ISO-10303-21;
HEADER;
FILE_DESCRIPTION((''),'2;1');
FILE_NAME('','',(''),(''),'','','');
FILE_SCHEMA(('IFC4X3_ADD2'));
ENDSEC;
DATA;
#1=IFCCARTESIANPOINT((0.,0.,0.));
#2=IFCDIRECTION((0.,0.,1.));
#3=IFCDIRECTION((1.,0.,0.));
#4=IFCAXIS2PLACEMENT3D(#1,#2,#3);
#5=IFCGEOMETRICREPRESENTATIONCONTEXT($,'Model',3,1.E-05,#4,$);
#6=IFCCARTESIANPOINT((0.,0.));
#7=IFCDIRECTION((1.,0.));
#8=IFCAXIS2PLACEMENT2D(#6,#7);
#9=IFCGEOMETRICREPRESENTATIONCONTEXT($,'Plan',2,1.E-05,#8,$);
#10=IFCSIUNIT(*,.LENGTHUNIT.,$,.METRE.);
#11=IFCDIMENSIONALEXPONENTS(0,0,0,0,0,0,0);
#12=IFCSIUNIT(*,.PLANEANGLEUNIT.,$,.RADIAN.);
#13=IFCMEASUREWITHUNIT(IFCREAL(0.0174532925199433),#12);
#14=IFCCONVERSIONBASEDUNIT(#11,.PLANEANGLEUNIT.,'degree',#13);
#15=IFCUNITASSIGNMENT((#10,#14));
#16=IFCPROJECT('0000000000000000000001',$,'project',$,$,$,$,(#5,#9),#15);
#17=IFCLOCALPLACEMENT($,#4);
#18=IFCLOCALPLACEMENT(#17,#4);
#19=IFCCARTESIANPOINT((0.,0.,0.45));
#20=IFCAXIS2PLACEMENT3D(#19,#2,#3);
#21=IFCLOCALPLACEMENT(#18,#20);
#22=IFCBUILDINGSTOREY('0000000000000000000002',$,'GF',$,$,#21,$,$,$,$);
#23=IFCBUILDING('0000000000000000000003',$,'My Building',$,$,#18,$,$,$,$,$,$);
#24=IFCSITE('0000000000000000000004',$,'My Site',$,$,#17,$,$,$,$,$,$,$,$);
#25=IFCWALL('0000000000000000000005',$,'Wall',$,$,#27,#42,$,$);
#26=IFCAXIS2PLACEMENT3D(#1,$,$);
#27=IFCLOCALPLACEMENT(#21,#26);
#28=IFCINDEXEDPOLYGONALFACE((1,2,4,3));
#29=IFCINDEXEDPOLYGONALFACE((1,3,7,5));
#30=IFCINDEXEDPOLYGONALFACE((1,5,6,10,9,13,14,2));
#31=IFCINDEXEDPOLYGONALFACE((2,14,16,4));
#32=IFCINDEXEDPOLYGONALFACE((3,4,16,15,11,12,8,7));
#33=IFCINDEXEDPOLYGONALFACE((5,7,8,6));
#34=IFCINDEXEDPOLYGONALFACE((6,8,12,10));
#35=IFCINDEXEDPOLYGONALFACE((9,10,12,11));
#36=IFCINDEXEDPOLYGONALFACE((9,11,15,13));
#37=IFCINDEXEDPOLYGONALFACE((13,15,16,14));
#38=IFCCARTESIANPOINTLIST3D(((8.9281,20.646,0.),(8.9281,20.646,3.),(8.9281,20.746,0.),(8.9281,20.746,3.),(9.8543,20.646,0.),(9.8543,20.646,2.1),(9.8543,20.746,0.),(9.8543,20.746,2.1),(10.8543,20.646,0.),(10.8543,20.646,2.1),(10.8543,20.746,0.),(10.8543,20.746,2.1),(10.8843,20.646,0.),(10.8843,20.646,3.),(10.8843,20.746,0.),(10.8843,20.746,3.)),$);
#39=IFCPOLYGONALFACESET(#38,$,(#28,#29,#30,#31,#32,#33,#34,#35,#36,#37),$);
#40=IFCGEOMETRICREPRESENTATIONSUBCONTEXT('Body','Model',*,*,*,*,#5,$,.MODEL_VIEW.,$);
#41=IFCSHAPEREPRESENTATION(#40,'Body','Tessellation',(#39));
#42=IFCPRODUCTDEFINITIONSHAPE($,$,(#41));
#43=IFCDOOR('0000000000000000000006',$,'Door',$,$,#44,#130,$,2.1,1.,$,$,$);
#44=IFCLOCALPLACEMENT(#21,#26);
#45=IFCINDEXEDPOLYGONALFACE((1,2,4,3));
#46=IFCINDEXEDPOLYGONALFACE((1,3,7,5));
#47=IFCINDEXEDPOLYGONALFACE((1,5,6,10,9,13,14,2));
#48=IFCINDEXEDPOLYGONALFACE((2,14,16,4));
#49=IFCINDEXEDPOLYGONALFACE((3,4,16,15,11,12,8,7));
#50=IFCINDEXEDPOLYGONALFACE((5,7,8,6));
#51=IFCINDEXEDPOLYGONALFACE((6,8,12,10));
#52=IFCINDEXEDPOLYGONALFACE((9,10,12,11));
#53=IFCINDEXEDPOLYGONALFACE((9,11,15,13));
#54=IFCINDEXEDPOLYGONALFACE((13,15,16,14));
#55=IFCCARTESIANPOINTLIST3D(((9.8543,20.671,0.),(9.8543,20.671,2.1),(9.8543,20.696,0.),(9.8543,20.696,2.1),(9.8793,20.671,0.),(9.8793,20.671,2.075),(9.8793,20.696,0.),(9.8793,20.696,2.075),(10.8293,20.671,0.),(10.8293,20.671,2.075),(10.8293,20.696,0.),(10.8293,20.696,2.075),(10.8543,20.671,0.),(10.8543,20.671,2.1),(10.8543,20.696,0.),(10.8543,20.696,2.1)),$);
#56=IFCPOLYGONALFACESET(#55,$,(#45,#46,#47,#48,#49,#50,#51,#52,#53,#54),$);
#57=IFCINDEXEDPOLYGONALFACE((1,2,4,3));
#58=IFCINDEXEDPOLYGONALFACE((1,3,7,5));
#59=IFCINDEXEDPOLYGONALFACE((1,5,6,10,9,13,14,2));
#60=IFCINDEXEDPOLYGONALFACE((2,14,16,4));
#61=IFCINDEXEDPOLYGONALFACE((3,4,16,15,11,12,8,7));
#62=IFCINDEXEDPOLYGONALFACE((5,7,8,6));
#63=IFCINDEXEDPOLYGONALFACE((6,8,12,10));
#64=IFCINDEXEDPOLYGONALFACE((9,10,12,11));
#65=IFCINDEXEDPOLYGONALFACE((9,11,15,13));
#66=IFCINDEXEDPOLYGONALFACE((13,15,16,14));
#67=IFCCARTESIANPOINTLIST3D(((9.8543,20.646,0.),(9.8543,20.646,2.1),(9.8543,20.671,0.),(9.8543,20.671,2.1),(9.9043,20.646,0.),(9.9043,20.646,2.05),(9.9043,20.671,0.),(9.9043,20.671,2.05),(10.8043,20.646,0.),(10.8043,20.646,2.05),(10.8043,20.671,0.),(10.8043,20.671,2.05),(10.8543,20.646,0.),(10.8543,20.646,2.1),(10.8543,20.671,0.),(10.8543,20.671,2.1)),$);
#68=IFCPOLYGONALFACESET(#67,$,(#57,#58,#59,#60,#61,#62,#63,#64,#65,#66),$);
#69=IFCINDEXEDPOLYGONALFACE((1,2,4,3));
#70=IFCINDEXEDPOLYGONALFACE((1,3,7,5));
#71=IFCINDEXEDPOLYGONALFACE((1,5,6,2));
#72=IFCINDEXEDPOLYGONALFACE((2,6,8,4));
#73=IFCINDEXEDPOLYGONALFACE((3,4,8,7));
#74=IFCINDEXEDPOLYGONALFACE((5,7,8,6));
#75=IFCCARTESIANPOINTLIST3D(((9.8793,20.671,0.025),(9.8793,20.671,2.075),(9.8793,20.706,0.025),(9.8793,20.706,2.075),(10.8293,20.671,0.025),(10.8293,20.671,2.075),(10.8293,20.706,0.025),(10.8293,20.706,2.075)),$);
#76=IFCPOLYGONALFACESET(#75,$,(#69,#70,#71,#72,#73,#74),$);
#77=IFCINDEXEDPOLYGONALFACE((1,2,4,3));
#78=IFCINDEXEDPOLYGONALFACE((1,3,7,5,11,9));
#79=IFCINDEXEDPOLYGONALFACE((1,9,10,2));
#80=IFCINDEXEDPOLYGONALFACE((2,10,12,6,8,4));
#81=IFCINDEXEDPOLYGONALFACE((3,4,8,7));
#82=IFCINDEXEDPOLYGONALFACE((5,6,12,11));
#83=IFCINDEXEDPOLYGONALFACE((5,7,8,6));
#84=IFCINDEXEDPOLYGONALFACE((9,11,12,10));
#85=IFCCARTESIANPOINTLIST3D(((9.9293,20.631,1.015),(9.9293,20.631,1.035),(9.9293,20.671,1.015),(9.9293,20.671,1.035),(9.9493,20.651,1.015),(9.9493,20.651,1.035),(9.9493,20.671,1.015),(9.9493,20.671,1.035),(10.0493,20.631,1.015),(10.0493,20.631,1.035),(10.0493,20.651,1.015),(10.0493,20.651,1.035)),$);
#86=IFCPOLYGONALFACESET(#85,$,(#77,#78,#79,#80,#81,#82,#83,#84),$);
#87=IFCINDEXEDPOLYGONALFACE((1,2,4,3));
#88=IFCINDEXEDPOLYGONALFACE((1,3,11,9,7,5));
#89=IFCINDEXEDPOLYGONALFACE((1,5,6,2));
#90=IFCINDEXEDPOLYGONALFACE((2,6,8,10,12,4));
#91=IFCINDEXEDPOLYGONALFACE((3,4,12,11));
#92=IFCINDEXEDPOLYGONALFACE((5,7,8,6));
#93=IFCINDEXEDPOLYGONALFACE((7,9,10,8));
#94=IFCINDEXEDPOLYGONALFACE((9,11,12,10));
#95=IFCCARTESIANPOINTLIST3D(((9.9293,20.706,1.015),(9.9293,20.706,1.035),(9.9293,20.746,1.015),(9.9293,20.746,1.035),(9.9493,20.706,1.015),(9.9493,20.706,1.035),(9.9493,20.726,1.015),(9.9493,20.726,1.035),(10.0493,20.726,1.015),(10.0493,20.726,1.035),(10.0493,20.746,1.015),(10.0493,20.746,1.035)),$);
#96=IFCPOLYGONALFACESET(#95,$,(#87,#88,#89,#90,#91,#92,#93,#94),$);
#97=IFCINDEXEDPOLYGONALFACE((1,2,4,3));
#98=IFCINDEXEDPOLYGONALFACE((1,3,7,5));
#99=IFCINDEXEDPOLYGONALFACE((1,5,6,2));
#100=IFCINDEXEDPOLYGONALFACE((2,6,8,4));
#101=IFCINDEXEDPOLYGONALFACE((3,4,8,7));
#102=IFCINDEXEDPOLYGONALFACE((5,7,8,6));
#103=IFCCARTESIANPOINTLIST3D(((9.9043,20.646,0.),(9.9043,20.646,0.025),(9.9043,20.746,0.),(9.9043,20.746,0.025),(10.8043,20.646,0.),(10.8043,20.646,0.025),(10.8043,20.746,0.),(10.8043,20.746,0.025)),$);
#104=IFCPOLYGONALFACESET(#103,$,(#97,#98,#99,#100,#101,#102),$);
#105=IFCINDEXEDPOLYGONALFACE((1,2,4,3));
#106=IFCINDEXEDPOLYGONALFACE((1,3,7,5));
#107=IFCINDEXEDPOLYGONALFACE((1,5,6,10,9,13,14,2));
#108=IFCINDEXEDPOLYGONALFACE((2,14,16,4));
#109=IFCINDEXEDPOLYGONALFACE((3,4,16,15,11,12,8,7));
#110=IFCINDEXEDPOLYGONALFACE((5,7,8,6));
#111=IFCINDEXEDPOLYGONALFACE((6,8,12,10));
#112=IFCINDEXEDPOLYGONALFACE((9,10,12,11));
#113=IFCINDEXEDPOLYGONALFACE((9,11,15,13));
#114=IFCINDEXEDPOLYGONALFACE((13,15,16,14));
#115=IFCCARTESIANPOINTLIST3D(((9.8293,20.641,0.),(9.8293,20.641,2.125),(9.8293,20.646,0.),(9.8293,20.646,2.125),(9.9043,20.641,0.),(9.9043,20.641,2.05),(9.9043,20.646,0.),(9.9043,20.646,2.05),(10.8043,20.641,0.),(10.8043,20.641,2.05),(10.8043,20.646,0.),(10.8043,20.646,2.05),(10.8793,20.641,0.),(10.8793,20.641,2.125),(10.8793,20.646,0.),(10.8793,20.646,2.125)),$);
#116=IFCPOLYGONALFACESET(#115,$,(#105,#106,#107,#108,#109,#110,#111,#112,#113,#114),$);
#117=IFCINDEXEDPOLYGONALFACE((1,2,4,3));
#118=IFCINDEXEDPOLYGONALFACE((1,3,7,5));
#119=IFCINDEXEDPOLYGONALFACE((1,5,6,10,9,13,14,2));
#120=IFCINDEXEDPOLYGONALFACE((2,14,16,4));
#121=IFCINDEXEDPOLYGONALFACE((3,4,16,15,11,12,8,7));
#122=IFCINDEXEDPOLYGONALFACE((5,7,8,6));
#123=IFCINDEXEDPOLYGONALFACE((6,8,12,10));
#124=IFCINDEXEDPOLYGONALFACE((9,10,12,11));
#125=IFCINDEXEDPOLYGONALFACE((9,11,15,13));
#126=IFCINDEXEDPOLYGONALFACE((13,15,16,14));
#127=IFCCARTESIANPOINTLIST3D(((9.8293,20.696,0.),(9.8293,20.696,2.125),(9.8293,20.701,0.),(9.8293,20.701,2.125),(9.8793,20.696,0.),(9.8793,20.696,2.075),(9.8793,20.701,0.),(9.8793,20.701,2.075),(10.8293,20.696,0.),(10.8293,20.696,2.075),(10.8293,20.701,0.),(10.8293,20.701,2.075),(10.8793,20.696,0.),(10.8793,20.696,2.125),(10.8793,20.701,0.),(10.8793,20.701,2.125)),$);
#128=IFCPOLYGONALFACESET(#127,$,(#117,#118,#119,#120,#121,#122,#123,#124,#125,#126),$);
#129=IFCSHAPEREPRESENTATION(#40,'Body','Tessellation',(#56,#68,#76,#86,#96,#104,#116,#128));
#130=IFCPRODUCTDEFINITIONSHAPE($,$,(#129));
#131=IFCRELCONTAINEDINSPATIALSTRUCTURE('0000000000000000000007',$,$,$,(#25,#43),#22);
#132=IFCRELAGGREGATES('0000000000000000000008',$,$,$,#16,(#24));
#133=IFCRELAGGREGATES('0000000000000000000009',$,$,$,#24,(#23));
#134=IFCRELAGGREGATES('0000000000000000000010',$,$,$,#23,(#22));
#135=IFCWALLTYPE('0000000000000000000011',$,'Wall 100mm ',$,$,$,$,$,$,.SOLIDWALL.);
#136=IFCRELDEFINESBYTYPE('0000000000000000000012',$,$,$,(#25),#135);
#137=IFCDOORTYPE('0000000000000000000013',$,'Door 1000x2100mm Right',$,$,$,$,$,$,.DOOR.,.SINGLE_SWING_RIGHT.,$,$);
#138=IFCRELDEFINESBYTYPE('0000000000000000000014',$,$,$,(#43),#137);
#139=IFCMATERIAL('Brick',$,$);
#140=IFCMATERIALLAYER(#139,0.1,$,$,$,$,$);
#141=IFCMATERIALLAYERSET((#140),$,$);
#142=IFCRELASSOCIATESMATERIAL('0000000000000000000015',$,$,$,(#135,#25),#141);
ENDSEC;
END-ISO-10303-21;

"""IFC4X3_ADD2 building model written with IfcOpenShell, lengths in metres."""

from ifc_helpers import new_model, entity, si_unit, converted_unit, frame, origin_with_axes, origin_2d_with_axis, place, context, subcontext, project, spatial, line, indexed_curve, outline, extrude, shape, source, transform, mapped, material, layer, layer_set, layer_usage, type_object, type_shapes, element, fill, save


model = new_model("IFC4X3_ADD2")

# Units and contexts
model_context = context("Model", 3, precision=1e-05, world=origin_with_axes())
plan_context = context("Plan", 2, precision=1e-05, world=origin_2d_with_axis())
body_context_1 = subcontext(model_context, "Body", "Model", "MODEL_VIEW")
body_context_2 = subcontext(plan_context, "Body", "Plan", "PLAN_VIEW")
ifc_project = project(units=[si_unit("LENGTHUNIT", "METRE"), converted_unit("PLANEANGLEUNIT", "degree", entity("IfcReal", 0.0174532925199433), si_unit("PLANEANGLEUNIT", "RADIAN"), dimensions=[0, 0, 0, 0, 0, 0, 0])], contexts=[model_context, plan_context])

# Site, building, storey
site_placement = place(None, origin_with_axes())
site = spatial("IfcSite", under=ifc_project, at=site_placement, Name="My Site")
building_placement = place(site_placement, origin_with_axes())
building = spatial("IfcBuilding", under=site, at=building_placement, Name="My Building")
storey_placement = place(building_placement, frame((0.0, 0.0, 0.45), z_axis=(0.0, 0.0, 1.0), x_axis=(1.0, 0.0, 0.0)))
storey = spatial("IfcBuildingStorey", under=building, at=storey_placement, Name="GF")

# Shared definitions
ifc_material = material(Name="Brick")

# Shared definitions
ifc_layer_1 = layer(ifc_material, 0.1)
ifc_layer_set_1 = layer_set([ifc_layer_1])
wall_type_1 = type_object("IfcWallType", Name="Wall 100mm ", PredefinedType="SOLIDWALL", material=ifc_layer_set_1)
shared_shape_1 = source(origin_with_axes(), body_context_1, "Body", "SweptSolid", [
    extrude(outline(indexed_curve([(0.0, 0.0), (1.0, 0.0), (1.0, 2.1), (0.0, 2.1)], segments=[line(1, 2, 3, 4, 1)])), frame((0.0, -0.6, 0.0), z_axis=(0.0, -1.0, 0.0), x_axis=(1.0, 0.0, 0.0)), (0.0, 0.0, -1.0), 1.2),
])
door_type_1 = type_object("IfcDoorType", Name="Door 1000x2100mm Right", OperationType="SINGLE_SWING_RIGHT", PredefinedType="DOOR")
shared_shape_2 = source(origin_with_axes(), body_context_1, "Body", "SweptSolid", [
    extrude(outline(indexed_curve([(0.0, 0.0), (0.0, 2.1), (1.0, 2.1), (1.0, 0.0), (0.975, 0.0), (0.975, 2.075), (0.025, 2.075), (0.025, 0.0)], segments=[line(1, 2, 3, 4, 5, 6, 7, 8, 1)])), frame((0.0, 0.025, 0.0), z_axis=(0.0, -1.0, 0.0), x_axis=(1.0, 0.0, 0.0)), (0.0, 0.0, -1.0), 0.025),
    extrude(outline(indexed_curve([(0.0, 0.0), (0.0, 2.1), (1.0, 2.1), (1.0, 0.0), (0.95, 0.0), (0.95, 2.05), (0.05, 2.05), (0.05, 0.0)], segments=[line(1, 2, 3, 4, 5, 6, 7, 8, 1)])), frame((0.0, 0.0, 0.0), z_axis=(0.0, -1.0, 0.0), x_axis=(1.0, 0.0, 0.0)), (0.0, 0.0, -1.0), 0.025),
    extrude(outline(indexed_curve([(0.0, 0.0), (0.95, 0.0), (0.95, 0.035), (0.0, 0.035)], segments=[line(1, 2, 3, 4, 1)])), frame((0.025, 0.025, 0.025), z_axis=(0.0, 0.0, 1.0), x_axis=(1.0, 0.0, 0.0)), (0.0, 0.0, 1.0), 2.05),
    extrude(outline(indexed_curve([(0.0, 0.0), (0.0, -0.04), (0.12, -0.04), (0.12, -0.02), (0.02, -0.02), (0.02, 0.0)], segments=[line(1, 2, 3, 4, 5, 6, 1)])), frame((0.075, 0.025, 1.015), z_axis=(0.0, 0.0, 1.0), x_axis=(1.0, 0.0, 0.0)), (0.0, 0.0, 1.0), 0.02),
    extrude(outline(indexed_curve([(0.0, 0.0), (0.0, 0.04), (0.12, 0.04), (0.12, 0.02), (0.02, 0.02), (0.02, 0.0)], segments=[line(1, 2, 3, 4, 5, 6, 1)])), frame((0.075, 0.06, 1.015), z_axis=(0.0, 0.0, 1.0), x_axis=(1.0, 0.0, 0.0)), (0.0, 0.0, 1.0), 0.02),
    extrude(outline(indexed_curve([(0.0, 0.0), (0.9, 0.0), (0.9, 0.1), (0.0, 0.1)], segments=[line(1, 2, 3, 4, 1)])), frame((0.05, 0.0, 0.0), z_axis=(0.0, 0.0, 1.0), x_axis=(1.0, 0.0, 0.0)), (0.0, 0.0, 1.0), 0.025),
    extrude(outline(indexed_curve([(0.0, 0.0), (0.0, 2.125), (1.05, 2.125), (1.05, 0.0), (0.975, 0.0), (0.975, 2.05), (0.075, 2.05), (0.075, 0.0)], segments=[line(1, 2, 3, 4, 5, 6, 7, 8, 1)])), frame((-0.025, -0.005, 0.0), z_axis=(0.0, -1.0, 0.0), x_axis=(1.0, 0.0, 0.0)), (0.0, 0.0, -1.0), 0.005),
    extrude(outline(indexed_curve([(0.0, 0.0), (0.0, 2.125), (1.05, 2.125), (1.05, 0.0), (1.0, 0.0), (1.0, 2.075), (0.05, 2.075), (0.05, 0.0)], segments=[line(1, 2, 3, 4, 5, 6, 7, 8, 1)])), frame((-0.025, 0.05, 0.0), z_axis=(0.0, -1.0, 0.0), x_axis=(1.0, 0.0, 0.0)), (0.0, 0.0, -1.0), 0.005),
])
shared_shape_3 = source(origin_with_axes(), body_context_2, "Body", "Curve2D", [
    entity("IfcIndexedPolyCurve", entity("IfcCartesianPointList2D", [[0.0, 0.0], [0.0, 0.05], [0.025, 0.05], [0.025, 0.025], [0.05, 0.025], [0.05, 0.0]]), [entity("IfcLineIndex", [1, 2, 3, 4, 5, 6, 1])]),
    entity("IfcIndexedPolyCurve", entity("IfcCartesianPointList2D", [[1.0, 0.0], [1.0, 0.05], [0.975, 0.05], [0.975, 0.025], [0.95, 0.025], [0.95, 0.0]]), [entity("IfcLineIndex", [1, 2, 3, 4, 5, 6, 1])]),
    entity("IfcTrimmedCurve", entity("IfcEllipse", entity("IfcAxis2Placement2D", entity("IfcCartesianPoint", [0.94, 0.05]), entity("IfcDirection", [1.0, 0.0])), 0.915, 0.95), [entity("IfcCartesianPoint", [0.94, 1.0])], [entity("IfcCartesianPoint", [0.025, 0.05])], True, "CARTESIAN"),
    entity("IfcIndexedPolyCurve", entity("IfcCartesianPointList2D", [[0.975, 0.05], [0.94, 0.05], [0.94, 1.0], [0.975, 1.0]]), [entity("IfcLineIndex", [1, 2, 3, 4, 1])]),
])
type_shapes(door_type_1, [shared_shape_2, shared_shape_3])

# Wall, opening, door
ifc_layer_usage_1 = layer_usage(ifc_layer_set_1, "AXIS2", "POSITIVE", 0.0)
wall_1_placement = place(storey_placement, frame((8.9281, 20.646, 0.0), z_axis=(0.0, 0.0, 1.0), x_axis=(1.0, 0.0, 0.0)))
wall_1 = element("IfcWall", 1, at=wall_1_placement, inside=storey, type_object=wall_type_1, material=ifc_layer_usage_1, Name="Wall", context=body_context_1, shape_type="SweptSolid", body=[
    extrude(outline(indexed_curve([(0.0, 0.0), (0.0, 0.1), (1.9562, 0.1), (1.9562, 0.0), (0.0, 0.0)], self_intersect=False)), origin_with_axes(), (0.0, 0.0, 1.0), 3.0),
])
opening_1_placement = place(wall_1_placement, frame((0.9262, 0.0, 0.0), z_axis=(0.0, 0.0, 1.0), x_axis=(1.0, 0.0, 0.0)))
opening_1 = element("IfcOpeningElement", 2, at=opening_1_placement, cuts=wall_1, PredefinedType="OPENING", context=body_context_1, shape_type="MappedRepresentation", body=[
    mapped(shared_shape_1, transform((0.0, 0.0, 0.0), x_axis=(1.0, 0.0, 0.0), y_axis=(0.0, 1.0, 0.0), z_axis=(0.0, 0.0, 1.0), scale=1.0)),
])
door_1_placement = place(opening_1_placement, origin_with_axes())
door_1 = element("IfcDoor", 3, at=door_1_placement, inside=storey, type_object=door_type_1, Name="Door", OverallHeight=2.1, OverallWidth=1.0, shapes=[
    shape(body_context_1, "Body", "MappedRepresentation", [mapped(shared_shape_2, transform((0.0, 0.0, 0.0), x_axis=(1.0, 0.0, 0.0), y_axis=(0.0, 1.0, 0.0), z_axis=(0.0, 0.0, 1.0), scale=1.0))]),
    shape(body_context_2, "Body", "MappedRepresentation", [mapped(shared_shape_3, transform((0.0, 0.0, 0.0), x_axis=(1.0, 0.0, 0.0), y_axis=(0.0, 1.0, 0.0), z_axis=(0.0, 0.0, 1.0), scale=1.0))]),
])
fill(opening_1, door_1)

save(model, "model.ifc")
